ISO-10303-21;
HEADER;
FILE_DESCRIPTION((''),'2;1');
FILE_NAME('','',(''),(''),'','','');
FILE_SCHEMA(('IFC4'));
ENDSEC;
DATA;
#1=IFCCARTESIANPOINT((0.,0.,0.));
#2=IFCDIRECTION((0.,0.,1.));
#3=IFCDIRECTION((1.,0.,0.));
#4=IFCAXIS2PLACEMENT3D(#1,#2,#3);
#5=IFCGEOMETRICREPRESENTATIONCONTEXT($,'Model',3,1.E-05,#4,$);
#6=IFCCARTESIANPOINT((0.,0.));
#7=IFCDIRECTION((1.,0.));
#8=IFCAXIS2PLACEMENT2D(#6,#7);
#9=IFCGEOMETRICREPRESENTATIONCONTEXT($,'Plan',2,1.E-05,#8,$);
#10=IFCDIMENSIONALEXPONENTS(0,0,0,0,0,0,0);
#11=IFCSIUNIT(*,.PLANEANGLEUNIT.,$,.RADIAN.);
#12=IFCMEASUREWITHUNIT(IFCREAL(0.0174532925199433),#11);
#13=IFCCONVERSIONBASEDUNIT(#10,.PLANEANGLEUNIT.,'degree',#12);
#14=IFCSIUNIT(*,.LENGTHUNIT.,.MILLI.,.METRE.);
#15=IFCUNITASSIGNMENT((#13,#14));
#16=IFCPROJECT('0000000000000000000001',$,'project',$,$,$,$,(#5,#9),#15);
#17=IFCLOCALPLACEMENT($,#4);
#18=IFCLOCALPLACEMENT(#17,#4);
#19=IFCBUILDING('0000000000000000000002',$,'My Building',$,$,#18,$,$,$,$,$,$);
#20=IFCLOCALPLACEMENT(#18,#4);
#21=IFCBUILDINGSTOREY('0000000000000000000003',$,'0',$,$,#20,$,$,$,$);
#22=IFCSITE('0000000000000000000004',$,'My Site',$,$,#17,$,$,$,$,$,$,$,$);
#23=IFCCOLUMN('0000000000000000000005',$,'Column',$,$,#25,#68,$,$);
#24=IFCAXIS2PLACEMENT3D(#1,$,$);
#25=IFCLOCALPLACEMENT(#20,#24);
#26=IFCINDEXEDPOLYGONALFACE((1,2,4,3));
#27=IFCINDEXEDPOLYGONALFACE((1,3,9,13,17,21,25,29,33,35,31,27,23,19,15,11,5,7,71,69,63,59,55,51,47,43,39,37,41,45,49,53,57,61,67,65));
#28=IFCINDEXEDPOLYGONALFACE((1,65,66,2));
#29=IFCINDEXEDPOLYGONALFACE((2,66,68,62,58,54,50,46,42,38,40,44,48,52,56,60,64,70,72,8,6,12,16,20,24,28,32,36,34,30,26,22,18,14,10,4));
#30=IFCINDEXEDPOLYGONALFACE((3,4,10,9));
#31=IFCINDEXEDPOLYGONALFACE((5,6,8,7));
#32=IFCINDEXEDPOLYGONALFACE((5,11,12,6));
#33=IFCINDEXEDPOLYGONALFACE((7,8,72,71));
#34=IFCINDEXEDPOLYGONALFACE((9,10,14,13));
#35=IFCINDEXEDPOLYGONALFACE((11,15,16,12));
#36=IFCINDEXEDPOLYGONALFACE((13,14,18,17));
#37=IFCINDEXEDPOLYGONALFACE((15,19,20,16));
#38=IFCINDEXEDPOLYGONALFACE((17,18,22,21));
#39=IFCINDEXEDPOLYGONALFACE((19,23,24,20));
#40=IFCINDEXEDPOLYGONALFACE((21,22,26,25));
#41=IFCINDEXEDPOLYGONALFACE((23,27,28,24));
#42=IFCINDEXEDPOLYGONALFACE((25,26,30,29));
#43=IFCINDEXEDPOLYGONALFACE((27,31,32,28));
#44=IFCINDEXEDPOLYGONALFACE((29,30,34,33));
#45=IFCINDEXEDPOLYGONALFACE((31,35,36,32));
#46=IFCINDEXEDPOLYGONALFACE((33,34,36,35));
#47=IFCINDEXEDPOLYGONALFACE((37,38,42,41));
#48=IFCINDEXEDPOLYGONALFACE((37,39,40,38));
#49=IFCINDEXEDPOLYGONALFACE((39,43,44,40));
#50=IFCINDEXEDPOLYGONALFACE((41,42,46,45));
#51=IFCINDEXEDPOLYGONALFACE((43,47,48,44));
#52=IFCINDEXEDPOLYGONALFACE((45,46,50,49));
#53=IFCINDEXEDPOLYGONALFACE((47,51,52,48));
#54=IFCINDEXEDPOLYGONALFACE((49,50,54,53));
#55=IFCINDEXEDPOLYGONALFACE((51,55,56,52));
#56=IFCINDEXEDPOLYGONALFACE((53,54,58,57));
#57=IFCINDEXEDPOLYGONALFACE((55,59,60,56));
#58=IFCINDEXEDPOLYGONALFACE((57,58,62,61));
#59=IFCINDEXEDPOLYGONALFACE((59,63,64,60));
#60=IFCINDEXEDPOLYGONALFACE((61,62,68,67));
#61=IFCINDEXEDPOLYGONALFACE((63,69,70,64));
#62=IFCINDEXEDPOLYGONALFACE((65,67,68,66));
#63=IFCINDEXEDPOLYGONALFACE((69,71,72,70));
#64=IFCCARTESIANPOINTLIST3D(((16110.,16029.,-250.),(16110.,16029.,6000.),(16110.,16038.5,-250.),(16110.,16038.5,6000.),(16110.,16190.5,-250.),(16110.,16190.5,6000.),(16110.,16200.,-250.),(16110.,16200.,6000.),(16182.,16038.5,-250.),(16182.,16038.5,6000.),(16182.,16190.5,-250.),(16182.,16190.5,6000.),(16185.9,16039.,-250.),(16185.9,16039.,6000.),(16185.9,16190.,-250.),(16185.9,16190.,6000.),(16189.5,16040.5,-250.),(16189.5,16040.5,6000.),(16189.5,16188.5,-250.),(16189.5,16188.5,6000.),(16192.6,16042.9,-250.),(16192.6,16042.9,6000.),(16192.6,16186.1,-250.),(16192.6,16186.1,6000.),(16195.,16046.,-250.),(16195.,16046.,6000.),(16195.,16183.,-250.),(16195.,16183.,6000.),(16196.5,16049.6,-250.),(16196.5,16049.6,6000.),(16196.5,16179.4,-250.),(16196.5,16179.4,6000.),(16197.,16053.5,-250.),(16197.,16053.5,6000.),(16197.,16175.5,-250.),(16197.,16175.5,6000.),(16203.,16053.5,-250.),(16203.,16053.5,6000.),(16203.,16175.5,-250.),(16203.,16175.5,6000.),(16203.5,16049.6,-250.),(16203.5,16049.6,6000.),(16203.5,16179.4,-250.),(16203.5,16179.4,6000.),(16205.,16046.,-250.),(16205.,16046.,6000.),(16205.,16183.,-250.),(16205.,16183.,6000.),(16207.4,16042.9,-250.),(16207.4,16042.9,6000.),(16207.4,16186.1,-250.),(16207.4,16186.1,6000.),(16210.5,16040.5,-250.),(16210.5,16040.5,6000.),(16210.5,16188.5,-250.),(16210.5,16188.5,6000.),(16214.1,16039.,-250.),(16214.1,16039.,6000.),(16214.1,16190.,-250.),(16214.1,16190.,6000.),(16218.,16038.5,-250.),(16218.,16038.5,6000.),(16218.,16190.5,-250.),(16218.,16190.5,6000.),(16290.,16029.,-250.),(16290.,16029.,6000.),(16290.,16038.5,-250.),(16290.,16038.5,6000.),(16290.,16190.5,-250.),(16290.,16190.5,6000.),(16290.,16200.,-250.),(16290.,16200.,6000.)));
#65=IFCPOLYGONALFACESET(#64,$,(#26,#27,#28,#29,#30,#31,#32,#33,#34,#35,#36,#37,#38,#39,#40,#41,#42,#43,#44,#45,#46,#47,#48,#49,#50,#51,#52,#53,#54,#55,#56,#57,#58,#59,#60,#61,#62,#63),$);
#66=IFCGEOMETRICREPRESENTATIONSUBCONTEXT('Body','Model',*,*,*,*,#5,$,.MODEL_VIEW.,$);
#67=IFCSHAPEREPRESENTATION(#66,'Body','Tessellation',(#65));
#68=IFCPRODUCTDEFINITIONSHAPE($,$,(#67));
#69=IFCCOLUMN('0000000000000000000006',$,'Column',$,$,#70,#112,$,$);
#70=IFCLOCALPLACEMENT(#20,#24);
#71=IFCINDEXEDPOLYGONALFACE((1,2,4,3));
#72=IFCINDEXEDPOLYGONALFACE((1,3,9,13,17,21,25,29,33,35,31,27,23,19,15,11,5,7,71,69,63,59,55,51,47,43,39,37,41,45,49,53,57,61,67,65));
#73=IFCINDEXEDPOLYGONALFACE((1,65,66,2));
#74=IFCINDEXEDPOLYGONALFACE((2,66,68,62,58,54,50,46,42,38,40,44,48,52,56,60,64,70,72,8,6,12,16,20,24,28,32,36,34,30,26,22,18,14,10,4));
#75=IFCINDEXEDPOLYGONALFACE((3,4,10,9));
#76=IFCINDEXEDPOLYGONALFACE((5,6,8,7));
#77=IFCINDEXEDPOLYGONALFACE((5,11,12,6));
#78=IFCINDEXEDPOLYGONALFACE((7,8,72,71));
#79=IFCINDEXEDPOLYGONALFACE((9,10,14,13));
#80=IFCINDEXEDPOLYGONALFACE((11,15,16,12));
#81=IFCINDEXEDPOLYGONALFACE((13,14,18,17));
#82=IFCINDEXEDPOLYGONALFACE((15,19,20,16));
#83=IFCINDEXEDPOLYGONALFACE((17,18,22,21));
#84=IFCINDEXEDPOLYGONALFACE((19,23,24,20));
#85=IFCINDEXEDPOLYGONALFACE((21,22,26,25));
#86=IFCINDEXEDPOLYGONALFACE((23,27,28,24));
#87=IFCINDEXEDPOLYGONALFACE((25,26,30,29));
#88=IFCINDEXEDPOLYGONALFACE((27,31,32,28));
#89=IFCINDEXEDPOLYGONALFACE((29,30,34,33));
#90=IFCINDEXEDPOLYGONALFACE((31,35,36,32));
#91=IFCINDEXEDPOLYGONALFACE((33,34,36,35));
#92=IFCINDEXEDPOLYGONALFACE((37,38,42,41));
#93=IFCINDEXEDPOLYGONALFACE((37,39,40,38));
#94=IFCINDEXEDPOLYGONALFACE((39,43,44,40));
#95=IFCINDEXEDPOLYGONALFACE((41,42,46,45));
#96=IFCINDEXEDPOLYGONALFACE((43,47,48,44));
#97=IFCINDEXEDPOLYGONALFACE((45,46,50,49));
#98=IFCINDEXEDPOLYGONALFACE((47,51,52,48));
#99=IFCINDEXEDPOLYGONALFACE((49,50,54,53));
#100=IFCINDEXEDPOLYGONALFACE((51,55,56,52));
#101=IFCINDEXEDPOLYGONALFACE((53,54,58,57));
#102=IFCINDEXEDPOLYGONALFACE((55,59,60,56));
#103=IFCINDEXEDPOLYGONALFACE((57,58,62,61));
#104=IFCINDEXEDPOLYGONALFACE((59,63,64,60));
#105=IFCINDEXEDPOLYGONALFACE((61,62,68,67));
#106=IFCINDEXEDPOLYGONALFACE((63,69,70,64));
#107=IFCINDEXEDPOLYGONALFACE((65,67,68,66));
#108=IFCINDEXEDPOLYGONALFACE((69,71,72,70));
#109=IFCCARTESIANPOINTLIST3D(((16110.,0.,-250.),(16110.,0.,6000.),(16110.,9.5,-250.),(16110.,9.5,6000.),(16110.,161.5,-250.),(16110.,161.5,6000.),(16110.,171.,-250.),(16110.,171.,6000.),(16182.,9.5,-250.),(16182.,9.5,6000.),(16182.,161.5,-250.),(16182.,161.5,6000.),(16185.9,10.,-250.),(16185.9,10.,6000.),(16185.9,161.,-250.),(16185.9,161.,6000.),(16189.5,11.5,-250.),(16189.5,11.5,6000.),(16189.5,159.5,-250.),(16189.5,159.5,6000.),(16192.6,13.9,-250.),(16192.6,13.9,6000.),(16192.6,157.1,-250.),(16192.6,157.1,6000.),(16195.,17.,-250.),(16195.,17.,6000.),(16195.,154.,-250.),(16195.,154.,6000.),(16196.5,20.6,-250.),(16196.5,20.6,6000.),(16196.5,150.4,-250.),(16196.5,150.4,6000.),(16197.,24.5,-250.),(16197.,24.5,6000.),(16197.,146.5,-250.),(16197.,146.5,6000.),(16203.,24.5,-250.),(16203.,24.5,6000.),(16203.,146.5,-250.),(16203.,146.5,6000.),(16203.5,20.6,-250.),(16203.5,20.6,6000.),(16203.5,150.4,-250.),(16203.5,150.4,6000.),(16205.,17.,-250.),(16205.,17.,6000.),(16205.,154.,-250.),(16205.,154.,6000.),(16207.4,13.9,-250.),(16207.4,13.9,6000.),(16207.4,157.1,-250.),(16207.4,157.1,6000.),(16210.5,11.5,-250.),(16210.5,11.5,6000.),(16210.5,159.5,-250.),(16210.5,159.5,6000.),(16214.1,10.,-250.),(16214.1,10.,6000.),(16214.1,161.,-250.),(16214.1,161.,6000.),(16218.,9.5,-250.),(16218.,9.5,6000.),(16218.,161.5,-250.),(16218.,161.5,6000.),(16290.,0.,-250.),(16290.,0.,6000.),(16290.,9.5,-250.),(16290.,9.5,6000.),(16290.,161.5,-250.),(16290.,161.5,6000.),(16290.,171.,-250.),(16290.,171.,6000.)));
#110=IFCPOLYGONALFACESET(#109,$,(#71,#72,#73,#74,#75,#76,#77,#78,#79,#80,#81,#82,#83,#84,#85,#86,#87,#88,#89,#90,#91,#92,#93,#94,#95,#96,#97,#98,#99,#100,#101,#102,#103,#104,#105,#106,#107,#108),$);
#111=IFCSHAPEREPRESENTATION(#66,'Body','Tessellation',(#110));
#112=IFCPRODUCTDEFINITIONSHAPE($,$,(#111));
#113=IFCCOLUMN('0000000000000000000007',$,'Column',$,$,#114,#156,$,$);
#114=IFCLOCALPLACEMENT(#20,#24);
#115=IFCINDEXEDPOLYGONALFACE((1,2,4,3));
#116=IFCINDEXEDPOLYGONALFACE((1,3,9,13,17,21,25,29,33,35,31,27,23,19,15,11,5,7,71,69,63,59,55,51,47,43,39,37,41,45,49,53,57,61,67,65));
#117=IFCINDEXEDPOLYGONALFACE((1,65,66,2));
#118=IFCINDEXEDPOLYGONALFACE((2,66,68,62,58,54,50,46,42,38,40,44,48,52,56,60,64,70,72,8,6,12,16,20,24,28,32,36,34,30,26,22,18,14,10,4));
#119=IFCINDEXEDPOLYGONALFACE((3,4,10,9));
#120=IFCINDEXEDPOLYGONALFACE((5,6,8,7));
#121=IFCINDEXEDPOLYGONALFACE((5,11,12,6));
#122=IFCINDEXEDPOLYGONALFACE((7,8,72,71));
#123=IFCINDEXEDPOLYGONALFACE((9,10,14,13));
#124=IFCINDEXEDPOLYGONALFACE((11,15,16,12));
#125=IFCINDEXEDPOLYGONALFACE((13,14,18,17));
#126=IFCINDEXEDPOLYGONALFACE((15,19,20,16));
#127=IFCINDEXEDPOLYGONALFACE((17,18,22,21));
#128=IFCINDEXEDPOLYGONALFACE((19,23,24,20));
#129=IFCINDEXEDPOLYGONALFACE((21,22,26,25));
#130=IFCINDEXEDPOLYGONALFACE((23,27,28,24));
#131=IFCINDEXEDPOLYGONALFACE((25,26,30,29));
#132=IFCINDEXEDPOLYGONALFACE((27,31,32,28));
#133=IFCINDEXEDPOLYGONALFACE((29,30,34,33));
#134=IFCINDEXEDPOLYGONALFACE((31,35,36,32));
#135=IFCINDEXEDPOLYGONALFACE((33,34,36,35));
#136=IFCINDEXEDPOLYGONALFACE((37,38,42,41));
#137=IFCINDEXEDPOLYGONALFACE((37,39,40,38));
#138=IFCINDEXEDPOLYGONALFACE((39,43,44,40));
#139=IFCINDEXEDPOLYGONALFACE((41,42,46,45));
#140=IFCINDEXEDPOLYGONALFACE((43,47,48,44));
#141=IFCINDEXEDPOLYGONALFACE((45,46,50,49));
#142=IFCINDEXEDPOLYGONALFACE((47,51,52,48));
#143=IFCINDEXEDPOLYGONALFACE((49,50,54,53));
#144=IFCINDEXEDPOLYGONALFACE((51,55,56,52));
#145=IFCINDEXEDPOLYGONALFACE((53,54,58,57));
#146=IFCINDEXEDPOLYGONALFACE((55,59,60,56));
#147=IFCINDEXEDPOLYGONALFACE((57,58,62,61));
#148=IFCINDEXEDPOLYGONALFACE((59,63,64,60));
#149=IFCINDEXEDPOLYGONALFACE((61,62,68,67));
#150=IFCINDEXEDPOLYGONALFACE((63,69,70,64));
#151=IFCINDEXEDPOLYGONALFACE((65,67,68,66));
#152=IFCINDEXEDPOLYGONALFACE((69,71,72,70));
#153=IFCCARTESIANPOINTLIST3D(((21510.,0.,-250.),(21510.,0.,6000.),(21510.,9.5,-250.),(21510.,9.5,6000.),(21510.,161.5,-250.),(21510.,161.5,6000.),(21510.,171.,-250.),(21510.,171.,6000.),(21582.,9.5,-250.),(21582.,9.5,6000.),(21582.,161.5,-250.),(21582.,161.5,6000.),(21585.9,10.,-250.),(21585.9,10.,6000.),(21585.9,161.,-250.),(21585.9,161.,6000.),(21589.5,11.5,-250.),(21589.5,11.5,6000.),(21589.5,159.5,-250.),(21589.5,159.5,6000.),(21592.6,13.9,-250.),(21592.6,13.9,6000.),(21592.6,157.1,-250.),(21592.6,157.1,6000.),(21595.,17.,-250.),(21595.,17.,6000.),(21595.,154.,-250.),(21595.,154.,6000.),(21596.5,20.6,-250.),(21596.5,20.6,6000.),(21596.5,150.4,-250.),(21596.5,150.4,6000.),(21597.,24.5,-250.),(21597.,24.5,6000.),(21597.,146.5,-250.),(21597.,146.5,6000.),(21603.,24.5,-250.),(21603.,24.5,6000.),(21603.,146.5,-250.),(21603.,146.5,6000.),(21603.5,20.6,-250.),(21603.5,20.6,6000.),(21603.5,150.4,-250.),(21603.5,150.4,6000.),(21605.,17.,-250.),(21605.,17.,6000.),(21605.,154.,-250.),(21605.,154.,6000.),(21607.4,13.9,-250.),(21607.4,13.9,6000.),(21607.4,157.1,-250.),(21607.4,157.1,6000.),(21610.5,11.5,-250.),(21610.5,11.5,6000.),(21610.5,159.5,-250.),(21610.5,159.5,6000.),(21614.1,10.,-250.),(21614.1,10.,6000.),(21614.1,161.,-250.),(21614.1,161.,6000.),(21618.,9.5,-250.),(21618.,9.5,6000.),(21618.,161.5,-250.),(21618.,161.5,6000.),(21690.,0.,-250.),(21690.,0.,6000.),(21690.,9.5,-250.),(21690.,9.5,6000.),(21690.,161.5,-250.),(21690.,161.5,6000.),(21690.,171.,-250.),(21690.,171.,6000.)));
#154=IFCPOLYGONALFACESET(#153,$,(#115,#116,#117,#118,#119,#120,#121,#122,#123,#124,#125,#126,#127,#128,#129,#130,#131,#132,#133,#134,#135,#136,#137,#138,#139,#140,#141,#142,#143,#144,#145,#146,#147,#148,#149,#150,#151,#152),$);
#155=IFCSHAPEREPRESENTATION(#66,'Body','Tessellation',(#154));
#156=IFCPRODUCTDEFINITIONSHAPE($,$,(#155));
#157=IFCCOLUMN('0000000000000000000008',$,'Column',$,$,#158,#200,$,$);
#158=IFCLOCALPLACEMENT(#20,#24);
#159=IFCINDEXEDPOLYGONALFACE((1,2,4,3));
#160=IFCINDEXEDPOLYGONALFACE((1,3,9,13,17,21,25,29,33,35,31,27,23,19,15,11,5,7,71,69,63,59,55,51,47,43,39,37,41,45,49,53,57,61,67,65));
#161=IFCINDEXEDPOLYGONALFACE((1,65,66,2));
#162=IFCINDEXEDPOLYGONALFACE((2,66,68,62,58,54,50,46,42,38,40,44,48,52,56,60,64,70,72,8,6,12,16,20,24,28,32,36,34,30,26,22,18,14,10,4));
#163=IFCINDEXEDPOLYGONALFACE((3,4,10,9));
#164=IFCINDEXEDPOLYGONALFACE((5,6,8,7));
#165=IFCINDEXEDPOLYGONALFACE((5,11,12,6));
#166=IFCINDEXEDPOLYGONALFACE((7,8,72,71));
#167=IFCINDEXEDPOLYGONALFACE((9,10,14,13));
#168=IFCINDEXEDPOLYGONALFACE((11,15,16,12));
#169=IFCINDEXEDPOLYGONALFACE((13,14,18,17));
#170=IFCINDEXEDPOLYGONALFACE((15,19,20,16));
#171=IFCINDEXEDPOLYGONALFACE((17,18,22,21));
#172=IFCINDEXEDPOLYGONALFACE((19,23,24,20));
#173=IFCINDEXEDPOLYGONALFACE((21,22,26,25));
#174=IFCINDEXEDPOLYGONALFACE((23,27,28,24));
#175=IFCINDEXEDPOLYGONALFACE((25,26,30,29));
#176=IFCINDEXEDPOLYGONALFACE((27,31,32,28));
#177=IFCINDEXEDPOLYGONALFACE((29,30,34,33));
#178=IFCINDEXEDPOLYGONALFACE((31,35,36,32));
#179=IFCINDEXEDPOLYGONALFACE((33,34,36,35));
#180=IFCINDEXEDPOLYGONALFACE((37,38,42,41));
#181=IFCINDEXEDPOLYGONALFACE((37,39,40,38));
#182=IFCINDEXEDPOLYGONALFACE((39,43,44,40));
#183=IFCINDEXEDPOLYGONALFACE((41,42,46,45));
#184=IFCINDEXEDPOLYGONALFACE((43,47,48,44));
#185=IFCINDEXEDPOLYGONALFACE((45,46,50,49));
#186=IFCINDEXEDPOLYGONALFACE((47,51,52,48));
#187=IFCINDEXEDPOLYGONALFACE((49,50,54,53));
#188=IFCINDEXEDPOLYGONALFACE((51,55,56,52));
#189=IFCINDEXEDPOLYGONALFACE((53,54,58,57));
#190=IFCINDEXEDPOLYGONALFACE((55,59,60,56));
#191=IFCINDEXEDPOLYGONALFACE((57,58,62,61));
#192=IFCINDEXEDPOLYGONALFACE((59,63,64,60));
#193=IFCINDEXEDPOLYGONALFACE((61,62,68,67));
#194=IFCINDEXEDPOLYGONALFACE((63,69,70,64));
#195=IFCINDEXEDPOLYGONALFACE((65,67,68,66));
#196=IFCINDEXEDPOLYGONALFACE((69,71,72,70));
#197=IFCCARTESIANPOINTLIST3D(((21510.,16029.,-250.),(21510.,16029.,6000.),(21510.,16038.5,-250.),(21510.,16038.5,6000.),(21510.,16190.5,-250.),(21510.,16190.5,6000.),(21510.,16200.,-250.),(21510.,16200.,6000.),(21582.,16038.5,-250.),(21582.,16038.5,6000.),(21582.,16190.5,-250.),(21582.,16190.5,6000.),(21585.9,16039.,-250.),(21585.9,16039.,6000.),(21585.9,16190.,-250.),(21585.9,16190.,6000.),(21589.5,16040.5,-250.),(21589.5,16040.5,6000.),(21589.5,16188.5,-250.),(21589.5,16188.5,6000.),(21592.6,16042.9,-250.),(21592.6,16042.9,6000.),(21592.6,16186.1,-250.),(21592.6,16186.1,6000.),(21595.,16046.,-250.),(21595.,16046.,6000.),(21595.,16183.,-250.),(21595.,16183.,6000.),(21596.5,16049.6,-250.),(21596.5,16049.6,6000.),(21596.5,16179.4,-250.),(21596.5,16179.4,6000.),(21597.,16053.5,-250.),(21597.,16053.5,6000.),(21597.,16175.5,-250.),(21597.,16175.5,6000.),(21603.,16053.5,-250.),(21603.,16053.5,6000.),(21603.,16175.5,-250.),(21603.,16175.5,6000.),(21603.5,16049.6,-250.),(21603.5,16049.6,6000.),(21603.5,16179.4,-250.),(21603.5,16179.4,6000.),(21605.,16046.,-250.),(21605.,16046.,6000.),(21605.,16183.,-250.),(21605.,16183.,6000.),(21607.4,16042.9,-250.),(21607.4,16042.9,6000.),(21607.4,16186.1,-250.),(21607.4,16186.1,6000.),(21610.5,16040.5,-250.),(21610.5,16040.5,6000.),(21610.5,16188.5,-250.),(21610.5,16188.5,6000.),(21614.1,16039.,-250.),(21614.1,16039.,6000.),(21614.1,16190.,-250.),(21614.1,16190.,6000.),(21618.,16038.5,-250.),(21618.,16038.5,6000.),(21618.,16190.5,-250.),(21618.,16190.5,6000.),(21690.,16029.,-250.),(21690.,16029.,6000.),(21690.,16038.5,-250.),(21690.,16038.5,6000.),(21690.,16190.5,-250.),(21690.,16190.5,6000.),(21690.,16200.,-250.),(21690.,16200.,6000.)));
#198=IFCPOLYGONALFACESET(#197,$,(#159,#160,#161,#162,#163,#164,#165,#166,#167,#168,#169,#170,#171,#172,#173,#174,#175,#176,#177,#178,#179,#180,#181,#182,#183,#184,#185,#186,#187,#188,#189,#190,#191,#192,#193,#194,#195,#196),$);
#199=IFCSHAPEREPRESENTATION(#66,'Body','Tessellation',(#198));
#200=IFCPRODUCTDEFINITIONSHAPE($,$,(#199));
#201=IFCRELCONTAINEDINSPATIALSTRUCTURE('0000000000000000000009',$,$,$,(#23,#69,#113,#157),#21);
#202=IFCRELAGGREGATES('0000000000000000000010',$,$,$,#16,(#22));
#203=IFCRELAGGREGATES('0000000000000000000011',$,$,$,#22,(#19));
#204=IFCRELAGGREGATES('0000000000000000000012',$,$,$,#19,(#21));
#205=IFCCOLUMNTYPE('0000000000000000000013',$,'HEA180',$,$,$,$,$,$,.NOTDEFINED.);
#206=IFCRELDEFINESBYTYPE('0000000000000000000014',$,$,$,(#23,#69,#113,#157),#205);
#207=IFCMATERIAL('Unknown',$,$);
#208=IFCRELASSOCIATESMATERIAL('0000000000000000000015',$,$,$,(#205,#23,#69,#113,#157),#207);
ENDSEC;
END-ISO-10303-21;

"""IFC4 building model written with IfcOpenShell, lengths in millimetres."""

from ifc_helpers import new_model, entity, si_unit, converted_unit, frame, origin_with_axes, origin_2d_with_axis, place, context, subcontext, project, spatial, i_section, extrude, material, material_profile, profile_set, profile_usage, type_object, element, save


model = new_model("IFC4")

# Units and contexts
model_context = context("Model", 3, precision=1e-05, world=origin_with_axes())
plan_context = context("Plan", 2, precision=1e-05, world=origin_2d_with_axis())
body_context = subcontext(model_context, "Body", "Model", "MODEL_VIEW")
ifc_project = project(units=[converted_unit("PLANEANGLEUNIT", "degree", entity("IfcReal", 0.0174532925199433), si_unit("PLANEANGLEUNIT", "RADIAN"), dimensions=[0, 0, 0, 0, 0, 0, 0]), si_unit("LENGTHUNIT", "METRE", prefix="MILLI")], contexts=[model_context, plan_context])

# Site, building, storey
site_placement = place(None, origin_with_axes())
site = spatial("IfcSite", under=ifc_project, at=site_placement, Name="My Site")
building_placement = place(site_placement, origin_with_axes())
building = spatial("IfcBuilding", under=site, at=building_placement, Name="My Building")
storey_placement = place(building_placement, origin_with_axes())
storey = spatial("IfcBuildingStorey", under=building, at=storey_placement, Name="0")

# Columns
ifc_material = material(Name="Unknown")
ifc_material_profile_1 = material_profile(ifc_material, i_section(OverallWidth=180.0, OverallDepth=171.0, WebThickness=6.0, FlangeThickness=9.5, FilletRadius=15.0))
ifc_profile_set_1 = profile_set([ifc_material_profile_1])
column_type = type_object("IfcColumnType", Name="HEA180", PredefinedType="NOTDEFINED", material=ifc_profile_set_1)
ifc_profile_usage_1 = profile_usage(ifc_profile_set_1, cardinal=8)
column_1_placement = place(storey_placement, frame((16200.0, 16200.0, -250.0), z_axis=(0.0, 0.0, 1.0), x_axis=(1.0, 0.0, 0.0)))
element("IfcColumn", 1, at=column_1_placement, inside=storey, type_object=column_type, material=ifc_profile_usage_1, Name="Column", context=body_context, shape_type="SweptSolid", body=[
    extrude(i_section(OverallWidth=180.0, OverallDepth=171.0, WebThickness=6.0, FlangeThickness=9.5, FilletRadius=15.0), frame((0.0, -85.5, 0.0), z_axis=(0.0, 0.0, 1.0), x_axis=(1.0, 0.0, 0.0)), (0.0, 0.0, 1.0), 6250.0),
])
ifc_profile_usage_2 = profile_usage(ifc_profile_set_1, cardinal=2)
column_2_placement = place(storey_placement, frame((16200.0, 0.0, -250.0), z_axis=(0.0, 0.0, 1.0), x_axis=(1.0, 0.0, 0.0)))
element("IfcColumn", 2, at=column_2_placement, inside=storey, type_object=column_type, material=ifc_profile_usage_2, Name="Column", context=body_context, shape_type="SweptSolid", body=[
    extrude(i_section(OverallWidth=180.0, OverallDepth=171.0, WebThickness=6.0, FlangeThickness=9.5, FilletRadius=15.0), frame((0.0, 85.5, 0.0), z_axis=(0.0, 0.0, 1.0), x_axis=(1.0, 0.0, 0.0)), (0.0, 0.0, 1.0), 6250.0),
])
ifc_profile_usage_3 = profile_usage(ifc_profile_set_1, cardinal=2)
column_3_placement = place(storey_placement, frame((21600.0, 0.0, -250.0), z_axis=(0.0, 0.0, 1.0), x_axis=(1.0, 0.0, 0.0)))
element("IfcColumn", 3, at=column_3_placement, inside=storey, type_object=column_type, material=ifc_profile_usage_3, Name="Column", context=body_context, shape_type="SweptSolid", body=[
    extrude(i_section(OverallWidth=180.0, OverallDepth=171.0, WebThickness=6.0, FlangeThickness=9.5, FilletRadius=15.0), frame((0.0, 85.5, 0.0), z_axis=(0.0, 0.0, 1.0), x_axis=(1.0, 0.0, 0.0)), (0.0, 0.0, 1.0), 6250.0),
])
ifc_profile_usage_4 = profile_usage(ifc_profile_set_1, cardinal=8)
column_4_placement = place(storey_placement, frame((21600.0, 16200.0, -250.0), z_axis=(0.0, 0.0, 1.0), x_axis=(1.0, 0.0, 0.0)))
element("IfcColumn", 4, at=column_4_placement, inside=storey, type_object=column_type, material=ifc_profile_usage_4, Name="Column", context=body_context, shape_type="SweptSolid", body=[
    extrude(i_section(OverallWidth=180.0, OverallDepth=171.0, WebThickness=6.0, FlangeThickness=9.5, FilletRadius=15.0), frame((0.0, -85.5, 0.0), z_axis=(0.0, 0.0, 1.0), x_axis=(1.0, 0.0, 0.0)), (0.0, 0.0, 1.0), 6250.0),
])

save(model, "model.ifc")
